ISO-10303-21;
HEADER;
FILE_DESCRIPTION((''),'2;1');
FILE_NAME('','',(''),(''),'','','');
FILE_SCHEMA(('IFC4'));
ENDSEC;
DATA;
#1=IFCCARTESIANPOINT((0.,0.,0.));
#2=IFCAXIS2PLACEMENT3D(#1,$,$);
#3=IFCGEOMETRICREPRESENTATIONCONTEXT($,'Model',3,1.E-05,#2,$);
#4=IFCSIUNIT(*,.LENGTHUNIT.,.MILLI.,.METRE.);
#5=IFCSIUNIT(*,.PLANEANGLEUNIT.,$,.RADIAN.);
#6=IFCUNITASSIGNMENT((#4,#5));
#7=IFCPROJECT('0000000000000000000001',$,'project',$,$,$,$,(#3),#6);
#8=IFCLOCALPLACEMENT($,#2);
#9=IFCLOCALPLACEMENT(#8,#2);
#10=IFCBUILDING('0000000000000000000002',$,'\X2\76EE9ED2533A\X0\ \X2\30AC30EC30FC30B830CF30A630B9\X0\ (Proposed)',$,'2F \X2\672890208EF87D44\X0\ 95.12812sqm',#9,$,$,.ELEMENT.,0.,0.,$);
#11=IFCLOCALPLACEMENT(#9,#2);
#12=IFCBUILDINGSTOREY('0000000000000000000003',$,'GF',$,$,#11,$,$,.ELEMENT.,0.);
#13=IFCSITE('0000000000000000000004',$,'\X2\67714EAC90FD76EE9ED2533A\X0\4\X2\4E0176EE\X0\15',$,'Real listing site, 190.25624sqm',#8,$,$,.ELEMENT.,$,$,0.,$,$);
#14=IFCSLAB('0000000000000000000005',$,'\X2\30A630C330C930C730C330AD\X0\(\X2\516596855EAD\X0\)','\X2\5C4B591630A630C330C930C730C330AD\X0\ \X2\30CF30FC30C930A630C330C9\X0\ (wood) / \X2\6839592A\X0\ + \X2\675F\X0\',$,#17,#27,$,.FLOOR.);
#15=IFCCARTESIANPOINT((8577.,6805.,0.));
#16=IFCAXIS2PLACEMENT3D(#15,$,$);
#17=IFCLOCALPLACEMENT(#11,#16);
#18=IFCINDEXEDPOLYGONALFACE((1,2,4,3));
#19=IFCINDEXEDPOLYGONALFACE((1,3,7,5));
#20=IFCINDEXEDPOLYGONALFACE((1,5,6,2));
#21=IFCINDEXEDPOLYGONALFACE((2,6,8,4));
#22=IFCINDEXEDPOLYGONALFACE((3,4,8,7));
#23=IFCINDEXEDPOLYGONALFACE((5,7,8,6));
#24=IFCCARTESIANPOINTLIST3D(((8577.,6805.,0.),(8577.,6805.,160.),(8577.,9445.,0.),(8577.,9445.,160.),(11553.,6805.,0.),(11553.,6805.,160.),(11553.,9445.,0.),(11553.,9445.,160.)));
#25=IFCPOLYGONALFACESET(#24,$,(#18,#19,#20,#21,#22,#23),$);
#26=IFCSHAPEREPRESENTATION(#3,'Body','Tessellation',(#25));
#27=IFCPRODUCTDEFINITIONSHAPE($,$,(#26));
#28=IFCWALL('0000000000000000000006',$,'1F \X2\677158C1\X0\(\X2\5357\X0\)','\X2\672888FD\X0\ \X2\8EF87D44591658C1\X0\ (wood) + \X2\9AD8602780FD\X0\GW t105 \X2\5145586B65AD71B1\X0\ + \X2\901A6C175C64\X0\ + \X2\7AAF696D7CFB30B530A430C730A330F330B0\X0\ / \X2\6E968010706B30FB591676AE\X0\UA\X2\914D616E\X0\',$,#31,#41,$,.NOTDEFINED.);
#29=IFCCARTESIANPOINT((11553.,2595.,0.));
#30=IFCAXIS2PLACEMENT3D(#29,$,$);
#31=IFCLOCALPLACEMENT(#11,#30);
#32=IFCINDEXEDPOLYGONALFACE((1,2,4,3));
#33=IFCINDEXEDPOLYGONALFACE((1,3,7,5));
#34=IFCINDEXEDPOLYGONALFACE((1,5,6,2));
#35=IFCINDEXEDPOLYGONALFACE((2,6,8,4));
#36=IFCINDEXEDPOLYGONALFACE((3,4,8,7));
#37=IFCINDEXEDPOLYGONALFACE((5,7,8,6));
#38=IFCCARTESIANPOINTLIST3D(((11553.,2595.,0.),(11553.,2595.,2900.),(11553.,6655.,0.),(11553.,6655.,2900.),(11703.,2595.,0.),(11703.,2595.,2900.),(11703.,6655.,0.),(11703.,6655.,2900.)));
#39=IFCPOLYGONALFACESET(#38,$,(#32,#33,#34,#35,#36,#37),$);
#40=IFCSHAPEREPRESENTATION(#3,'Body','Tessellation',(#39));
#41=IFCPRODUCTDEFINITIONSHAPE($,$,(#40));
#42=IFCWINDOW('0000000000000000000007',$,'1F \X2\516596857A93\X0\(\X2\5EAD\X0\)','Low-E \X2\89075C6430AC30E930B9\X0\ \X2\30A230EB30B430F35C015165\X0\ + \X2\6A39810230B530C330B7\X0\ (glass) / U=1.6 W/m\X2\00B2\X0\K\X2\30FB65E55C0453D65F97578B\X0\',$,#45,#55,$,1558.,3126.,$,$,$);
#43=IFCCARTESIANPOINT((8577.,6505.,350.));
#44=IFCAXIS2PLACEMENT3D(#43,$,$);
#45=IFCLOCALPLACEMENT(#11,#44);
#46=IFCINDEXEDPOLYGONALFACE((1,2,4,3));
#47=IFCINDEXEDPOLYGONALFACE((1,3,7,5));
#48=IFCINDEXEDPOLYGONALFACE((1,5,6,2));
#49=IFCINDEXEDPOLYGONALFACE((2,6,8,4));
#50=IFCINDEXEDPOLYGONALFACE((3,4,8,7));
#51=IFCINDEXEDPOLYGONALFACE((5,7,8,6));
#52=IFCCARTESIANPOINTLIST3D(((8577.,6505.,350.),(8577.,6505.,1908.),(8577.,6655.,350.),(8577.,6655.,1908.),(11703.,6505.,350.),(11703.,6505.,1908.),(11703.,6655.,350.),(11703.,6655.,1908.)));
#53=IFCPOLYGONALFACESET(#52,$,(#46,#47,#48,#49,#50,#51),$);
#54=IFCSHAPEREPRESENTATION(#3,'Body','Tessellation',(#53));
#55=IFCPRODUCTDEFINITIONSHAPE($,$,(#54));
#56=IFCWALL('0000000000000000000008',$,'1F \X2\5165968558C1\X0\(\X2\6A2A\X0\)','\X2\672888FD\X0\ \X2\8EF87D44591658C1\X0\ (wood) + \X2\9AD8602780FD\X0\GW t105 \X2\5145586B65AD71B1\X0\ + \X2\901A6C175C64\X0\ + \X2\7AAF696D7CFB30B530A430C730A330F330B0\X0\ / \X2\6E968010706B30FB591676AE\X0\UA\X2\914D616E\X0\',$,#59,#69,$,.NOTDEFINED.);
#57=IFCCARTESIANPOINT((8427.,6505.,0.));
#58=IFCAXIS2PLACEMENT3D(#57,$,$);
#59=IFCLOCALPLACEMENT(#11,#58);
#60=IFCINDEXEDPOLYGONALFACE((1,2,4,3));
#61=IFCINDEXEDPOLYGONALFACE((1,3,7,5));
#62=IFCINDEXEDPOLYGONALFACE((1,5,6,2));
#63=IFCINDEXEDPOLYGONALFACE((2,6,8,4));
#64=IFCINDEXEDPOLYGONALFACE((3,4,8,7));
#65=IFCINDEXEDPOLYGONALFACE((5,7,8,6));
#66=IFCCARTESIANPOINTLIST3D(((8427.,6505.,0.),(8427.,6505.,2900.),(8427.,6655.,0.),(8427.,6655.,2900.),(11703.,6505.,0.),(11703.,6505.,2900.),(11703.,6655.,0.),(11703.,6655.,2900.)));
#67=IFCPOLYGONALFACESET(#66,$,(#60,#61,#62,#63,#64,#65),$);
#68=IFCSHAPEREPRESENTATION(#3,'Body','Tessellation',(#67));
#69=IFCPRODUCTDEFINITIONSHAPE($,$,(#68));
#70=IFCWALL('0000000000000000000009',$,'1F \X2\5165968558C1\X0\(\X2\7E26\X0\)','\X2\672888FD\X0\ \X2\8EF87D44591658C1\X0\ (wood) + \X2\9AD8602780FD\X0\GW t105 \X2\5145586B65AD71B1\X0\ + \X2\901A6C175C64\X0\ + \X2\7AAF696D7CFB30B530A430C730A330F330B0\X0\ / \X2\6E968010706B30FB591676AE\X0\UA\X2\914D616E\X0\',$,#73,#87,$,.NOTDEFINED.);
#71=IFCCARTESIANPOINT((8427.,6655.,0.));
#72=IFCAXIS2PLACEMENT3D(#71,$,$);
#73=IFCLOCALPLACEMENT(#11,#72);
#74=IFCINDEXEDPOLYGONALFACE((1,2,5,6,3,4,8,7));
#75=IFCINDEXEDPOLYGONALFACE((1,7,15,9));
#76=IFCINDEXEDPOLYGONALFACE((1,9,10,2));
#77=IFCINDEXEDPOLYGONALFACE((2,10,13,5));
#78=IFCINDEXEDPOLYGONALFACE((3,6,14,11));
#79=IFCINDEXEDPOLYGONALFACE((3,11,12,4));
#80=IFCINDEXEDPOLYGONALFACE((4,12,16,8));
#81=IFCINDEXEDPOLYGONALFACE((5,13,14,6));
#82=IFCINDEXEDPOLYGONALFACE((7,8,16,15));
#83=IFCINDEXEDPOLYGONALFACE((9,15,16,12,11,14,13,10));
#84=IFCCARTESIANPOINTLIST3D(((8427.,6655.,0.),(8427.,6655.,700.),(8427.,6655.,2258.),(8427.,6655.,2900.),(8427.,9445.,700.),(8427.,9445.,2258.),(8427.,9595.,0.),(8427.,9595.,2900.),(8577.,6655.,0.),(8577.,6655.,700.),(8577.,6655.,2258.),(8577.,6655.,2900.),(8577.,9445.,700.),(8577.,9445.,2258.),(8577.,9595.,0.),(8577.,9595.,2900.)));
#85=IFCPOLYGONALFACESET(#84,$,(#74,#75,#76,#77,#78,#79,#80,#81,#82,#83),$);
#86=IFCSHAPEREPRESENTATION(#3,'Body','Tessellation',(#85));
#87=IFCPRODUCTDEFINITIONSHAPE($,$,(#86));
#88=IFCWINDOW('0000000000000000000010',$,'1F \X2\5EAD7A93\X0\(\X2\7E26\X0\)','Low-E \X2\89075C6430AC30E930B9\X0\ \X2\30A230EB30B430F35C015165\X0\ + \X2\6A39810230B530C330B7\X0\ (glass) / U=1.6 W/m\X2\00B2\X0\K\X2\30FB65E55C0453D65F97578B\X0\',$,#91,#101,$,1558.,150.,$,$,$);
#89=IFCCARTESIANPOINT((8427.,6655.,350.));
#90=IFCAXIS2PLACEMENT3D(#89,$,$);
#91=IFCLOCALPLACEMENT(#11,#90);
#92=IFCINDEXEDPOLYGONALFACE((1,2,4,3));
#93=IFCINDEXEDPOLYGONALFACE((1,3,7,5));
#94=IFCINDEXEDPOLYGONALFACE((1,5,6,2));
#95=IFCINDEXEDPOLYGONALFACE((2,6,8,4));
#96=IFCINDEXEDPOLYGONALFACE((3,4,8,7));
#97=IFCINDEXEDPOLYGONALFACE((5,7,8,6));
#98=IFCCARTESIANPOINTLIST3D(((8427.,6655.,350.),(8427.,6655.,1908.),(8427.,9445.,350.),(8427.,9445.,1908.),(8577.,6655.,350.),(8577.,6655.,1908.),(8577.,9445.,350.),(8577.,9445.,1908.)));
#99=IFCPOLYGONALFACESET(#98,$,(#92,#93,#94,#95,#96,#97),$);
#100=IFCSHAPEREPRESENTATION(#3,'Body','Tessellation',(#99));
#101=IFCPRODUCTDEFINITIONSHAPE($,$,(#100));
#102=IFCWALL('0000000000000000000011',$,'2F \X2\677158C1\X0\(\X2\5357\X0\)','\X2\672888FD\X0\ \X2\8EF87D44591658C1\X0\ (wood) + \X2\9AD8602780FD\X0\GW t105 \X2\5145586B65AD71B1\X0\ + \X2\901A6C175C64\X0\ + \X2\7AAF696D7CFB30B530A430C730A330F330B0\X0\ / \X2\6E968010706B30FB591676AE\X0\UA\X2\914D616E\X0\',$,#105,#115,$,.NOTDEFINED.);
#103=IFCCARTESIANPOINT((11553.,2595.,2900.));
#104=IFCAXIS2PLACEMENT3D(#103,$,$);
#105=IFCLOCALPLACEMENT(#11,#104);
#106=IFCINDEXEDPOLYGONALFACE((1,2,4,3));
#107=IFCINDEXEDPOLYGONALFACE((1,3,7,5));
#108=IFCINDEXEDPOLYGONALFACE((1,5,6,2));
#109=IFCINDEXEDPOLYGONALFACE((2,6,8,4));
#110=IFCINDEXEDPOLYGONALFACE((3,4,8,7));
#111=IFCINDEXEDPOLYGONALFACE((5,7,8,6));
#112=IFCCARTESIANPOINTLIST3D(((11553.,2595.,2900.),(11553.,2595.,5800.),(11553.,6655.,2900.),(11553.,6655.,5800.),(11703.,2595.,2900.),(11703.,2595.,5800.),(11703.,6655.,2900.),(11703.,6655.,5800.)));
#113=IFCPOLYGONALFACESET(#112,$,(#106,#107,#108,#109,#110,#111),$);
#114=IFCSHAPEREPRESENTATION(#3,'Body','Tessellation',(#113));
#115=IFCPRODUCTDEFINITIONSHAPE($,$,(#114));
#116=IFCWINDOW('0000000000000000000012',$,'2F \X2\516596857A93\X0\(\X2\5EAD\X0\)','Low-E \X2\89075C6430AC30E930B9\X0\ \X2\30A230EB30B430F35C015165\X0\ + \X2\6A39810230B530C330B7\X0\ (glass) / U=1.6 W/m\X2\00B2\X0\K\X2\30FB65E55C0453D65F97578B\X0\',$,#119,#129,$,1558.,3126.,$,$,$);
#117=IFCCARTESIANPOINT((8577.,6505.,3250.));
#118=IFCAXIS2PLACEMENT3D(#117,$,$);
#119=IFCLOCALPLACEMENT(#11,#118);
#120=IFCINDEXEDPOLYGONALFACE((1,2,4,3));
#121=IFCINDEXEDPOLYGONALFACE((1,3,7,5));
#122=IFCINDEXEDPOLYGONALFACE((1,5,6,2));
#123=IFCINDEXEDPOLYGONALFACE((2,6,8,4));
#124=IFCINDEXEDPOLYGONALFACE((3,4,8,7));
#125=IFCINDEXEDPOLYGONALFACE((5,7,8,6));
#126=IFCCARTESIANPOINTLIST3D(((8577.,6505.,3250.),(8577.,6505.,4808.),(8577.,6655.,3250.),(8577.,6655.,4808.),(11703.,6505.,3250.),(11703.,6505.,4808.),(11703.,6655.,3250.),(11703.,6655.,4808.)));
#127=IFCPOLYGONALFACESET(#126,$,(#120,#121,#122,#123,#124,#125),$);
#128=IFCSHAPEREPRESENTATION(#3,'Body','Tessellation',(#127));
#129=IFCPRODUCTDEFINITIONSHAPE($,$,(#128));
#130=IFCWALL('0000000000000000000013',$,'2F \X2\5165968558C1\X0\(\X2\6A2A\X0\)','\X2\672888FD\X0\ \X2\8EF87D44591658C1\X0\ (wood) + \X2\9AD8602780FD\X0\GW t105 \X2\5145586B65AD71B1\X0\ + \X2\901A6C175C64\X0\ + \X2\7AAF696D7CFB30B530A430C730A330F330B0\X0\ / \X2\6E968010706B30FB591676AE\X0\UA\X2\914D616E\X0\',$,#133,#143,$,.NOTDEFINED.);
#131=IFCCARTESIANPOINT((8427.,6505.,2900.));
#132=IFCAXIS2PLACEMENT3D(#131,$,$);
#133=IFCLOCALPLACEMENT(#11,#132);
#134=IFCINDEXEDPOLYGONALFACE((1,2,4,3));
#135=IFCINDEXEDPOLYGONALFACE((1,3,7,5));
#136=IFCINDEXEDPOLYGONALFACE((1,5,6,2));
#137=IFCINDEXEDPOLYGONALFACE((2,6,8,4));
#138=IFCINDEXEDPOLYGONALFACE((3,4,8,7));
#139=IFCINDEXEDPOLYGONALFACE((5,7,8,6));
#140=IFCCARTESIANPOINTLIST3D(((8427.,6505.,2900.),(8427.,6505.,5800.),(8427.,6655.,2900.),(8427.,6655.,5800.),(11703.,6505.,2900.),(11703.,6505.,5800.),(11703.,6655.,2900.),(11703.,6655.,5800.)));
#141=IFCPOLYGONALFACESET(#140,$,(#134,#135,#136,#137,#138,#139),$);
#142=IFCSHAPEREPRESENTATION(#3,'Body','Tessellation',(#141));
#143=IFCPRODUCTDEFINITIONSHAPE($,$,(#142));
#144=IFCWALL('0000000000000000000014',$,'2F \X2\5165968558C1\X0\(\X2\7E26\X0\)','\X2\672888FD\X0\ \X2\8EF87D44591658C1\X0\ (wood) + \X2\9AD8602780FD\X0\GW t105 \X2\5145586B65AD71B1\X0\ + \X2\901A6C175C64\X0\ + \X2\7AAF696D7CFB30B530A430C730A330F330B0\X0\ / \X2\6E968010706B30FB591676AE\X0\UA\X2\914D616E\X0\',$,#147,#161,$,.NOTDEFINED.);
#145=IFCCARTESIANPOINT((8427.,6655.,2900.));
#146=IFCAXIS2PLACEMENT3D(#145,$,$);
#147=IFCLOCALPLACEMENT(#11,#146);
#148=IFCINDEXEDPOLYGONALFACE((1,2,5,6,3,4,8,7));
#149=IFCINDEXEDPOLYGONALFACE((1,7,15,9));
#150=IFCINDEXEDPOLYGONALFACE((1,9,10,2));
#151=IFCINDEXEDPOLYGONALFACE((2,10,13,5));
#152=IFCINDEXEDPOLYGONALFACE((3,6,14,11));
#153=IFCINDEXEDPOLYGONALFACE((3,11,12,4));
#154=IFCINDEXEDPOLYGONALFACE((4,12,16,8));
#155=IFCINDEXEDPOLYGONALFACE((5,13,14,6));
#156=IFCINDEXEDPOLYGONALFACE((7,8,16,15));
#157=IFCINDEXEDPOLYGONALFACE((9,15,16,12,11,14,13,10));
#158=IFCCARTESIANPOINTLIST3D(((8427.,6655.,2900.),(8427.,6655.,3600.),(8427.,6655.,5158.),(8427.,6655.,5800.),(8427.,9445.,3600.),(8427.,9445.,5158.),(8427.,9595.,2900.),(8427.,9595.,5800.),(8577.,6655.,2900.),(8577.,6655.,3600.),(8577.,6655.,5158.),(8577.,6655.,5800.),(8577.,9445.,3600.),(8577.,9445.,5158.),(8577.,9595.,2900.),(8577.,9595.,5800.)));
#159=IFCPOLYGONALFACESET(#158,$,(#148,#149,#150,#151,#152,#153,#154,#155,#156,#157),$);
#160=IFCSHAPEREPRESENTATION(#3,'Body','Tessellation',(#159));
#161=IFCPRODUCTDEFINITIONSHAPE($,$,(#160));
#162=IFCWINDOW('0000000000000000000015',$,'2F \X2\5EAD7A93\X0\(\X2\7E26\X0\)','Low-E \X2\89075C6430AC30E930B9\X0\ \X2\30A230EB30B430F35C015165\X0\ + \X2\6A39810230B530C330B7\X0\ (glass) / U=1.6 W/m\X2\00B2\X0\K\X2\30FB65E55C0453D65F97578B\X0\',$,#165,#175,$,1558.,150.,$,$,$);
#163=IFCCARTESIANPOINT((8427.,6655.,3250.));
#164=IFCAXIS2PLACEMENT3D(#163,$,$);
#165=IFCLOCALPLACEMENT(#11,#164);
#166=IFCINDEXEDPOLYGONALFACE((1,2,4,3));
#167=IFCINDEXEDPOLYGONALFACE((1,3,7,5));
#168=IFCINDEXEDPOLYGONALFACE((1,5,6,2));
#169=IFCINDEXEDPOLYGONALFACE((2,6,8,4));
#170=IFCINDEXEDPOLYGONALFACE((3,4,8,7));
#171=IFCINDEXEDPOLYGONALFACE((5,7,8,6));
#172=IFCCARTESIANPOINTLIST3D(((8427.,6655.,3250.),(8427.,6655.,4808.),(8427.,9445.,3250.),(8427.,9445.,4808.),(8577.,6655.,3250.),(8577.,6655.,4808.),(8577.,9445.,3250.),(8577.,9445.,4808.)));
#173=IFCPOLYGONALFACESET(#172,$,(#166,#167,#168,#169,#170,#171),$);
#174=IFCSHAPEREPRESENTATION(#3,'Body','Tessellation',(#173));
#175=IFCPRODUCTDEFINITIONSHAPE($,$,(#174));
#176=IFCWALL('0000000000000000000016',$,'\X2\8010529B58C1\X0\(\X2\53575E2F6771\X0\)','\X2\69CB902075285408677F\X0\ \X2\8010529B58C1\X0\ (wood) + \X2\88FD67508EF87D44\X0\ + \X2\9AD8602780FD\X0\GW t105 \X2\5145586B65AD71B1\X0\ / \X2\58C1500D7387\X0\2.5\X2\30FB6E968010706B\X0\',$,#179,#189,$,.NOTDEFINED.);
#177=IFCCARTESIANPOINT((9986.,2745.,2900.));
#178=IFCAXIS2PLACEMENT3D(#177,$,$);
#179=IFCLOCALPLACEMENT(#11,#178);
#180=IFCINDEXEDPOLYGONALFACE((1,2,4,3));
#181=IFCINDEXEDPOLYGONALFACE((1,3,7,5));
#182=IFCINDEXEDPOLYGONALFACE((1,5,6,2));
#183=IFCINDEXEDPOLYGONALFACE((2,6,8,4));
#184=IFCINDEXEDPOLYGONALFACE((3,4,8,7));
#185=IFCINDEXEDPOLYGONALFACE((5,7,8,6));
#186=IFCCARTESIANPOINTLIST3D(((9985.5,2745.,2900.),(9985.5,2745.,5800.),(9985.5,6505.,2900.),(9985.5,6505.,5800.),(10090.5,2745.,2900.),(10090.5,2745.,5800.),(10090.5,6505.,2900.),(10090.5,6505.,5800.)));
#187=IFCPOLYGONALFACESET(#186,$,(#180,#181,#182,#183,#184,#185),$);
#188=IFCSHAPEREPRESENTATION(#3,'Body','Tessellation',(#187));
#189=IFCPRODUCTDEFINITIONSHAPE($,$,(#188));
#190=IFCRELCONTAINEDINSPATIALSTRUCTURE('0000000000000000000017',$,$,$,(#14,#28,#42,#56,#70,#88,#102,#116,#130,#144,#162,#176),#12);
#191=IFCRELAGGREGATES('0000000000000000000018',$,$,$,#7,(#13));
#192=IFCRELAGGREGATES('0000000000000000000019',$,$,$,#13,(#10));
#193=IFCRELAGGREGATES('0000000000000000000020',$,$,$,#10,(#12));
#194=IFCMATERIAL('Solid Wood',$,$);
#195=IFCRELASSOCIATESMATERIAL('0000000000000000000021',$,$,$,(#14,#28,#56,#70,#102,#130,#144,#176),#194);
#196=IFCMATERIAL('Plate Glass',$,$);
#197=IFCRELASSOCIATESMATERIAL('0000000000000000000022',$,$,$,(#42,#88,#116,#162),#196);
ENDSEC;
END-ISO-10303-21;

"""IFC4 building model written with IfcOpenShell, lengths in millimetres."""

from ifc_helpers import new_model, si_unit, frame, frame_2d, origin, place, context, project, spatial, rectangle, extrude, material, element, fill, save


model = new_model("IFC4")

# Units and contexts
model_context = context("Model", 3, precision=1e-05, world=origin())
ifc_project = project(units=[si_unit("LENGTHUNIT", "METRE", prefix="MILLI"), si_unit("PLANEANGLEUNIT", "RADIAN")], contexts=[model_context])

# Site, building, storey
site_placement = place(None, origin())
site = spatial("IfcSite", under=ifc_project, at=site_placement, Name="東京都目黒区4丁目15", ObjectType="Real listing site, 190.25624sqm", CompositionType="ELEMENT", RefElevation=0.0)
building_placement = place(site_placement, origin())
building = spatial("IfcBuilding", under=site, at=building_placement, Name="目黒区 ガレージハウス (Proposed)", ObjectType="2F 木造軸組 95.12812sqm", CompositionType="ELEMENT", ElevationOfRefHeight=0.0, ElevationOfTerrain=0.0)
storey_placement = place(building_placement, origin())
storey = spatial("IfcBuildingStorey", under=building, at=storey_placement, Name="GF", CompositionType="ELEMENT", Elevation=0.0)

# Slab
ifc_material_1 = material(Name="Solid Wood")
slab_placement = place(storey_placement, frame((8577.0, 6805.0, 0.0)))
element("IfcSlab", 1, at=slab_placement, inside=storey, material=ifc_material_1, Name="ウッドデッキ(入隅庭)", Description="屋外ウッドデッキ ハードウッド (wood) / 根太 + 束", PredefinedType="FLOOR", context=model_context, shape_type="SweptSolid", body=[
    extrude(rectangle(XDim=2976.0, YDim=2640.0, at=frame_2d((1488.0, 1320.0))), frame((8577.0, 6805.0, 0.0)), (0.0, 0.0, 1.0), 160.0),
])

# Wall, opening, window
wall_1_placement = place(storey_placement, frame((11553.0, 2595.0, 0.0)))
wall_1 = element("IfcWall", 2, at=wall_1_placement, inside=storey, material=ifc_material_1, Name="1F 東壁(南)", Description="木製 軸組外壁 (wood) + 高性能GW t105 充填断熱 + 通気層 + 窯業系サイディング / 準耐火・外皮UA配慮", PredefinedType="NOTDEFINED", context=model_context, shape_type="SweptSolid", body=[
    extrude(rectangle(XDim=150.0, YDim=4060.0, at=frame_2d((75.0, 2030.0))), frame((11553.0, 2595.0, 0.0)), (0.0, 0.0, 1.0), 2900.0),
])
opening_1_placement = place(storey_placement, frame((8577.0, 6505.0, 350.0)))
opening_1 = element("IfcOpeningElement", 3, at=opening_1_placement, cuts=wall_1, PredefinedType="NOTDEFINED", context=model_context, shape_type="SweptSolid", body=[
    extrude(rectangle(XDim=3126.0, YDim=150.0, at=frame_2d((1563.0, 75.0))), frame((8577.0, 6505.0, 350.0)), (0.0, 0.0, 1.0), 1558.0),
])
ifc_material_2 = material(Name="Plate Glass")
window_1_placement = place(storey_placement, frame((8577.0, 6505.0, 350.0)))
window_1 = element("IfcWindow", 4, at=window_1_placement, inside=storey, material=ifc_material_2, Name="1F 入隅窓(庭)", Description="Low-E 複層ガラス アルゴン封入 + 樹脂サッシ (glass) / U=1.6 W/m²K・日射取得型", OverallHeight=1558.0, OverallWidth=3126.0, context=model_context, shape_type="SweptSolid", body=[
    extrude(rectangle(XDim=3126.0, YDim=150.0, at=frame_2d((1563.0, 75.0))), frame((8577.0, 6505.0, 350.0)), (0.0, 0.0, 1.0), 1558.0),
])
fill(opening_1, window_1)

# Wall
wall_2_placement = place(storey_placement, frame((8427.0, 6505.0, 0.0)))
element("IfcWall", 5, at=wall_2_placement, inside=storey, material=ifc_material_1, Name="1F 入隅壁(横)", Description="木製 軸組外壁 (wood) + 高性能GW t105 充填断熱 + 通気層 + 窯業系サイディング / 準耐火・外皮UA配慮", PredefinedType="NOTDEFINED", context=model_context, shape_type="SweptSolid", body=[
    extrude(rectangle(XDim=3276.0, YDim=150.0, at=frame_2d((1638.0, 75.0))), frame((8427.0, 6505.0, 0.0)), (0.0, 0.0, 1.0), 2900.0),
])

# Wall, opening, window
wall_3_placement = place(storey_placement, frame((8427.0, 6655.0, 0.0)))
wall_3 = element("IfcWall", 6, at=wall_3_placement, inside=storey, material=ifc_material_1, Name="1F 入隅壁(縦)", Description="木製 軸組外壁 (wood) + 高性能GW t105 充填断熱 + 通気層 + 窯業系サイディング / 準耐火・外皮UA配慮", PredefinedType="NOTDEFINED", context=model_context, shape_type="SweptSolid", body=[
    extrude(rectangle(XDim=150.0, YDim=2940.0, at=frame_2d((75.0, 1470.0))), frame((8427.0, 6655.0, 0.0)), (0.0, 0.0, 1.0), 2900.0),
])
opening_2_placement = place(storey_placement, frame((8427.0, 6655.0, 350.0)))
opening_2 = element("IfcOpeningElement", 7, at=opening_2_placement, cuts=wall_3, PredefinedType="NOTDEFINED", context=model_context, shape_type="SweptSolid", body=[
    extrude(rectangle(XDim=150.0, YDim=2790.0, at=frame_2d((75.0, 1395.0))), frame((8427.0, 6655.0, 350.0)), (0.0, 0.0, 1.0), 1558.0),
])
window_2_placement = place(storey_placement, frame((8427.0, 6655.0, 350.0)))
window_2 = element("IfcWindow", 8, at=window_2_placement, inside=storey, material=ifc_material_2, Name="1F 庭窓(縦)", Description="Low-E 複層ガラス アルゴン封入 + 樹脂サッシ (glass) / U=1.6 W/m²K・日射取得型", OverallHeight=1558.0, OverallWidth=150.0, context=model_context, shape_type="SweptSolid", body=[
    extrude(rectangle(XDim=150.0, YDim=2790.0, at=frame_2d((75.0, 1395.0))), frame((8427.0, 6655.0, 350.0)), (0.0, 0.0, 1.0), 1558.0),
])
fill(opening_2, window_2)

# Wall, opening, window
wall_4_placement = place(storey_placement, frame((11553.0, 2595.0, 2900.0)))
wall_4 = element("IfcWall", 9, at=wall_4_placement, inside=storey, material=ifc_material_1, Name="2F 東壁(南)", Description="木製 軸組外壁 (wood) + 高性能GW t105 充填断熱 + 通気層 + 窯業系サイディング / 準耐火・外皮UA配慮", PredefinedType="NOTDEFINED", context=model_context, shape_type="SweptSolid", body=[
    extrude(rectangle(XDim=150.0, YDim=4060.0, at=frame_2d((75.0, 2030.0))), frame((11553.0, 2595.0, 2900.0)), (0.0, 0.0, 1.0), 2900.0),
])
opening_3_placement = place(storey_placement, frame((8577.0, 6505.0, 3250.0)))
opening_3 = element("IfcOpeningElement", 10, at=opening_3_placement, cuts=wall_4, PredefinedType="NOTDEFINED", context=model_context, shape_type="SweptSolid", body=[
    extrude(rectangle(XDim=3126.0, YDim=150.0, at=frame_2d((1563.0, 75.0))), frame((8577.0, 6505.0, 3250.0)), (0.0, 0.0, 1.0), 1558.0),
])
window_3_placement = place(storey_placement, frame((8577.0, 6505.0, 3250.0)))
window_3 = element("IfcWindow", 11, at=window_3_placement, inside=storey, material=ifc_material_2, Name="2F 入隅窓(庭)", Description="Low-E 複層ガラス アルゴン封入 + 樹脂サッシ (glass) / U=1.6 W/m²K・日射取得型", OverallHeight=1558.0, OverallWidth=3126.0, context=model_context, shape_type="SweptSolid", body=[
    extrude(rectangle(XDim=3126.0, YDim=150.0, at=frame_2d((1563.0, 75.0))), frame((8577.0, 6505.0, 3250.0)), (0.0, 0.0, 1.0), 1558.0),
])
fill(opening_3, window_3)

# Wall
wall_5_placement = place(storey_placement, frame((8427.0, 6505.0, 2900.0)))
element("IfcWall", 12, at=wall_5_placement, inside=storey, material=ifc_material_1, Name="2F 入隅壁(横)", Description="木製 軸組外壁 (wood) + 高性能GW t105 充填断熱 + 通気層 + 窯業系サイディング / 準耐火・外皮UA配慮", PredefinedType="NOTDEFINED", context=model_context, shape_type="SweptSolid", body=[
    extrude(rectangle(XDim=3276.0, YDim=150.0, at=frame_2d((1638.0, 75.0))), frame((8427.0, 6505.0, 2900.0)), (0.0, 0.0, 1.0), 2900.0),
])

# Wall, opening, window
wall_6_placement = place(storey_placement, frame((8427.0, 6655.0, 2900.0)))
wall_6 = element("IfcWall", 13, at=wall_6_placement, inside=storey, material=ifc_material_1, Name="2F 入隅壁(縦)", Description="木製 軸組外壁 (wood) + 高性能GW t105 充填断熱 + 通気層 + 窯業系サイディング / 準耐火・外皮UA配慮", PredefinedType="NOTDEFINED", context=model_context, shape_type="SweptSolid", body=[
    extrude(rectangle(XDim=150.0, YDim=2940.0, at=frame_2d((75.0, 1470.0))), frame((8427.0, 6655.0, 2900.0)), (0.0, 0.0, 1.0), 2900.0),
])
opening_4_placement = place(storey_placement, frame((8427.0, 6655.0, 3250.0)))
opening_4 = element("IfcOpeningElement", 14, at=opening_4_placement, cuts=wall_6, PredefinedType="NOTDEFINED", context=model_context, shape_type="SweptSolid", body=[
    extrude(rectangle(XDim=150.0, YDim=2790.0, at=frame_2d((75.0, 1395.0))), frame((8427.0, 6655.0, 3250.0)), (0.0, 0.0, 1.0), 1558.0),
])
window_4_placement = place(storey_placement, frame((8427.0, 6655.0, 3250.0)))
window_4 = element("IfcWindow", 15, at=window_4_placement, inside=storey, material=ifc_material_2, Name="2F 庭窓(縦)", Description="Low-E 複層ガラス アルゴン封入 + 樹脂サッシ (glass) / U=1.6 W/m²K・日射取得型", OverallHeight=1558.0, OverallWidth=150.0, context=model_context, shape_type="SweptSolid", body=[
    extrude(rectangle(XDim=150.0, YDim=2790.0, at=frame_2d((75.0, 1395.0))), frame((8427.0, 6655.0, 3250.0)), (0.0, 0.0, 1.0), 1558.0),
])
fill(opening_4, window_4)

# Wall
wall_7_placement = place(storey_placement, frame((9986.0, 2745.0, 2900.0)))
element("IfcWall", 16, at=wall_7_placement, inside=storey, material=ifc_material_1, Name="耐力壁(南帯東)", Description="構造用合板 耐力壁 (wood) + 製材軸組 + 高性能GW t105 充填断熱 / 壁倍率2.5・準耐火", PredefinedType="NOTDEFINED", context=model_context, shape_type="SweptSolid", body=[
    extrude(rectangle(XDim=105.0, YDim=3760.0, at=frame_2d((52.0, 1880.0))), frame((9986.0, 2745.0, 2900.0)), (0.0, 0.0, 1.0), 2900.0),
])

save(model, "model.ifc")
